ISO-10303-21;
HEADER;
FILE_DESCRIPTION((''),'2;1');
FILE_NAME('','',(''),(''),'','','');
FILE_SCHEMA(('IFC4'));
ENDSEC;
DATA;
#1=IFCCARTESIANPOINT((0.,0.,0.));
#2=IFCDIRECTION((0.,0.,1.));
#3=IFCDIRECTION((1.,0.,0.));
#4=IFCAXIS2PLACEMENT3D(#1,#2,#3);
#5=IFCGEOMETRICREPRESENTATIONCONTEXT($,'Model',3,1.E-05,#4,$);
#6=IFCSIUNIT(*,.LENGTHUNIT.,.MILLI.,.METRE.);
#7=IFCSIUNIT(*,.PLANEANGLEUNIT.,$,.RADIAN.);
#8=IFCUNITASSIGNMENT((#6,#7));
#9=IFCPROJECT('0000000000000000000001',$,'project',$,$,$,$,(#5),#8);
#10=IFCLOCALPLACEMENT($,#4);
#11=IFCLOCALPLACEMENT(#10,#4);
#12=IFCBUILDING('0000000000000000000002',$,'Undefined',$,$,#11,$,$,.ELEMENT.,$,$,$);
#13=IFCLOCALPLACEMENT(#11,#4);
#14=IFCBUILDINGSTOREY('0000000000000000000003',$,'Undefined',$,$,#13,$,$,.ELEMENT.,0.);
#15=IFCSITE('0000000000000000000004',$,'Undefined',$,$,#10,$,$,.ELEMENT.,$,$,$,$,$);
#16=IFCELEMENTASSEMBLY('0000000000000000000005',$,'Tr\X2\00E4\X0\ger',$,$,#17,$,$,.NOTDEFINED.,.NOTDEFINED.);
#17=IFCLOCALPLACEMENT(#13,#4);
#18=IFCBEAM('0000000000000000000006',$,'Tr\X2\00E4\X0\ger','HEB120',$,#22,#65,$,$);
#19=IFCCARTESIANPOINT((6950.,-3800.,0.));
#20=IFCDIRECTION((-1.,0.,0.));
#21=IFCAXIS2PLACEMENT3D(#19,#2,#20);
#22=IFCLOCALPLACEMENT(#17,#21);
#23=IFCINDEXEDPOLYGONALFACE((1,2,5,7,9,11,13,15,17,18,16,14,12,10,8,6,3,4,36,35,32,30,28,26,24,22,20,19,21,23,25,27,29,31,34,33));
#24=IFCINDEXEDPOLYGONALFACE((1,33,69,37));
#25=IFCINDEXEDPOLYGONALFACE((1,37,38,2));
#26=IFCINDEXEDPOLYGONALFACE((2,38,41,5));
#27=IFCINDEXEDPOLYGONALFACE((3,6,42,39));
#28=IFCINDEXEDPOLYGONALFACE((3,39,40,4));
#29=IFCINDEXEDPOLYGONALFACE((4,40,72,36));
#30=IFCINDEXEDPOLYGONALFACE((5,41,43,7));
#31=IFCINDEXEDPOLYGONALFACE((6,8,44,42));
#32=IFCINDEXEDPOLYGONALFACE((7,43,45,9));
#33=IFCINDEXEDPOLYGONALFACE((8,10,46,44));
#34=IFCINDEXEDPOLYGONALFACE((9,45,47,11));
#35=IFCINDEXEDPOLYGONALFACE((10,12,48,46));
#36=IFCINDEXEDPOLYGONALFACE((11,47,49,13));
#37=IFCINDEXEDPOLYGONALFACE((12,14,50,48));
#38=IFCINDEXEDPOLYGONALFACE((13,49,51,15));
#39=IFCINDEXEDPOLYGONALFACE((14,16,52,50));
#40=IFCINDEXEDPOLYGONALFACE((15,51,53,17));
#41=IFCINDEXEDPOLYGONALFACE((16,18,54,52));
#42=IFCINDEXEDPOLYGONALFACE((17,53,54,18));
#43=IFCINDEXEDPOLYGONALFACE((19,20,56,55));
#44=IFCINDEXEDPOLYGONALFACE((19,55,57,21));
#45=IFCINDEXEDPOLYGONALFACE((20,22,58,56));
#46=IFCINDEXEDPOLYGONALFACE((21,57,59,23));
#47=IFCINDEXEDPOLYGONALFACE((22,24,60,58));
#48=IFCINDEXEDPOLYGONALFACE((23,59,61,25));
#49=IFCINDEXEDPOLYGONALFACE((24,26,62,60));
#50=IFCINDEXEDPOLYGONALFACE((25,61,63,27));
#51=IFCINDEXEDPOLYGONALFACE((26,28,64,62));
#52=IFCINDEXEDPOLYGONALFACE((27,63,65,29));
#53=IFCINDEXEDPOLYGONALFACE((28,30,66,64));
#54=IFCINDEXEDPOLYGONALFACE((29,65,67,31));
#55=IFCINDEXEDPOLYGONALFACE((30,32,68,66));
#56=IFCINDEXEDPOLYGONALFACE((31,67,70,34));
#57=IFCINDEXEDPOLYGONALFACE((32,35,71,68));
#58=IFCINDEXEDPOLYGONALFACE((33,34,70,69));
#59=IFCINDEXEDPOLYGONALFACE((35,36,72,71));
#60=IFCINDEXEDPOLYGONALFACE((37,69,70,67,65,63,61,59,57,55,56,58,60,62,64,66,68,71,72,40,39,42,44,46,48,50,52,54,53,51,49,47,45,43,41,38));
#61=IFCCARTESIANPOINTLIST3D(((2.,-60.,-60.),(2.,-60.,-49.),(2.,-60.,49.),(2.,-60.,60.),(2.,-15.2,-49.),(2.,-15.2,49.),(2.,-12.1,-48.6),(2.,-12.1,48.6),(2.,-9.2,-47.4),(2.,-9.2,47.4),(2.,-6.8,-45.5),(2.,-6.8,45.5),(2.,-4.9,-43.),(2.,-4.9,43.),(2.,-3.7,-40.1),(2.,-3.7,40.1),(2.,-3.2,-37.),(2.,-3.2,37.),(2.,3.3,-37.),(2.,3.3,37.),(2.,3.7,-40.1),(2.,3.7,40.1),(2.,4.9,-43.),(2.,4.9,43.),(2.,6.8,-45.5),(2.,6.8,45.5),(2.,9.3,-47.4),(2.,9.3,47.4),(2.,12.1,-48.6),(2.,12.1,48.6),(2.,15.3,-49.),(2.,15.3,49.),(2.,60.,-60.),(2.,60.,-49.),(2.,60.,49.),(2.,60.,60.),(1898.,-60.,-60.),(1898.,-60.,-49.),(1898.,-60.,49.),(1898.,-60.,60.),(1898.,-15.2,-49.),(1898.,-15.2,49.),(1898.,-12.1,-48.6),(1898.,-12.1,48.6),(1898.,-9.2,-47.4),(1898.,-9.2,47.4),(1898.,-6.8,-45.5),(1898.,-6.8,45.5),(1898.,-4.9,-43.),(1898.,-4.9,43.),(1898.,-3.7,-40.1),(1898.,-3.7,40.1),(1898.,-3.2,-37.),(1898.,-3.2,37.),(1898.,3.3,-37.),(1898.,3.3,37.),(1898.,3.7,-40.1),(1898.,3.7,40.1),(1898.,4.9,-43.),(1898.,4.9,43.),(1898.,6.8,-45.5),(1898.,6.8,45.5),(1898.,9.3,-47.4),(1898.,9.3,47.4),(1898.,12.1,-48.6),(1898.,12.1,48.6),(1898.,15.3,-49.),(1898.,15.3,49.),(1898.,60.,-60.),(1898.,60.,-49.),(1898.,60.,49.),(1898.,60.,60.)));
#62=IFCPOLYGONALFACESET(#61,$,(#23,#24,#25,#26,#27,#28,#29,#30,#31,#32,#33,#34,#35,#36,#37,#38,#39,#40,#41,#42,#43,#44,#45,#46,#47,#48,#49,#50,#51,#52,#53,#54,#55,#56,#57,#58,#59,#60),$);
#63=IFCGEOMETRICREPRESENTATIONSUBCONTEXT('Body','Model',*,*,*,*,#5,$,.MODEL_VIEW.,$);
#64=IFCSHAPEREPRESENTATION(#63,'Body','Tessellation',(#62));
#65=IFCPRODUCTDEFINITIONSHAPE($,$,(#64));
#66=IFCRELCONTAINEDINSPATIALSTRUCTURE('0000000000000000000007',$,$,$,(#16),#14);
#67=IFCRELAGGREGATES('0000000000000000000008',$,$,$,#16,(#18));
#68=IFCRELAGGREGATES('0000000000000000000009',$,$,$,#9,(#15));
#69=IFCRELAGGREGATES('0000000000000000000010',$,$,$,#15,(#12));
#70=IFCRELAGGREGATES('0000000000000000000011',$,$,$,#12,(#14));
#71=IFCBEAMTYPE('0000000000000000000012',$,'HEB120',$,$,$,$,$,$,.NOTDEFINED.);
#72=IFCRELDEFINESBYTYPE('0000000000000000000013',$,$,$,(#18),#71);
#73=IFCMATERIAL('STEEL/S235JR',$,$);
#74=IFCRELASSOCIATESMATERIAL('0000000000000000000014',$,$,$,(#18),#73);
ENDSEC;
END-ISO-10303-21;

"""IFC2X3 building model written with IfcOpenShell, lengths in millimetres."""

from ifc_helpers import new_model, si_unit, frame, origin_with_axes, origin_2d_with_axis, place, context, subcontext, project, spatial, i_section, extrude, clip, halfspace, material, type_object, element, aggregate, save


model = new_model("IFC2X3")

# Units and contexts
model_context = context("Model", 3, precision=1e-05, world=origin_with_axes())
body_context = subcontext(model_context, "Body", "Model", "MODEL_VIEW")
ifc_project = project(units=[si_unit("LENGTHUNIT", "METRE", prefix="MILLI"), si_unit("PLANEANGLEUNIT", "RADIAN")], contexts=[model_context])

# Site, building, storey
site_placement = place(None, origin_with_axes())
site = spatial("IfcSite", under=ifc_project, at=site_placement, Name="Undefined", CompositionType="ELEMENT")
building_placement = place(site_placement, origin_with_axes())
building = spatial("IfcBuilding", under=site, at=building_placement, Name="Undefined", CompositionType="ELEMENT")
storey_placement = place(building_placement, origin_with_axes())
storey = spatial("IfcBuildingStorey", under=building, at=storey_placement, Name="Undefined", CompositionType="ELEMENT", Elevation=0.0)

# Shared definitions
ifc_material_1 = material(Name="STEEL/S235JR")

# Element assembly, beam
beam_type_1 = type_object("IfcBeamType", Name="HEB120", PredefinedType="NOTDEFINED")
assembly_1_placement = place(storey_placement, origin_with_axes())
assembly_1 = element("IfcElementAssembly", 1, at=assembly_1_placement, inside=storey, Name="Träger", AssemblyPlace="NOTDEFINED", PredefinedType="NOTDEFINED")
beam_1_placement = place(assembly_1_placement, frame((6950.0, -3800.0, 0.0), z_axis=(0.0, 0.0, 1.0), x_axis=(-1.0, 0.0, 0.0)))
beam_1 = element("IfcBeam", 2, at=beam_1_placement, type_object=beam_type_1, material=ifc_material_1, Name="Träger", Description="HEB120", context=body_context, shape_type="Clipping", body=[
    clip(clip(extrude(i_section(OverallWidth=120.0, OverallDepth=120.0, WebThickness=6.5, FlangeThickness=11.0, FilletRadius=12.0, at=origin_2d_with_axis()), frame((1910.0, 0.0, 0.0), z_axis=(-1.0, 0.0, 0.0), x_axis=(0.0, -1.0, 0.0)), (0.0, 0.0, 1.0), 1910.0), halfspace(frame((1898.0, 0.0, -60.0), z_axis=(-1.0, 0.0, 0.0), x_axis=(0.0, 1.0, 0.0)), True)), halfspace(frame((2.0, 0.0, -60.0), z_axis=(1.0, 0.0, 0.0), x_axis=(0.0, -1.0, 0.0)), True)),
])

aggregate(assembly_1, [beam_1])

save(model, "model.ifc")
